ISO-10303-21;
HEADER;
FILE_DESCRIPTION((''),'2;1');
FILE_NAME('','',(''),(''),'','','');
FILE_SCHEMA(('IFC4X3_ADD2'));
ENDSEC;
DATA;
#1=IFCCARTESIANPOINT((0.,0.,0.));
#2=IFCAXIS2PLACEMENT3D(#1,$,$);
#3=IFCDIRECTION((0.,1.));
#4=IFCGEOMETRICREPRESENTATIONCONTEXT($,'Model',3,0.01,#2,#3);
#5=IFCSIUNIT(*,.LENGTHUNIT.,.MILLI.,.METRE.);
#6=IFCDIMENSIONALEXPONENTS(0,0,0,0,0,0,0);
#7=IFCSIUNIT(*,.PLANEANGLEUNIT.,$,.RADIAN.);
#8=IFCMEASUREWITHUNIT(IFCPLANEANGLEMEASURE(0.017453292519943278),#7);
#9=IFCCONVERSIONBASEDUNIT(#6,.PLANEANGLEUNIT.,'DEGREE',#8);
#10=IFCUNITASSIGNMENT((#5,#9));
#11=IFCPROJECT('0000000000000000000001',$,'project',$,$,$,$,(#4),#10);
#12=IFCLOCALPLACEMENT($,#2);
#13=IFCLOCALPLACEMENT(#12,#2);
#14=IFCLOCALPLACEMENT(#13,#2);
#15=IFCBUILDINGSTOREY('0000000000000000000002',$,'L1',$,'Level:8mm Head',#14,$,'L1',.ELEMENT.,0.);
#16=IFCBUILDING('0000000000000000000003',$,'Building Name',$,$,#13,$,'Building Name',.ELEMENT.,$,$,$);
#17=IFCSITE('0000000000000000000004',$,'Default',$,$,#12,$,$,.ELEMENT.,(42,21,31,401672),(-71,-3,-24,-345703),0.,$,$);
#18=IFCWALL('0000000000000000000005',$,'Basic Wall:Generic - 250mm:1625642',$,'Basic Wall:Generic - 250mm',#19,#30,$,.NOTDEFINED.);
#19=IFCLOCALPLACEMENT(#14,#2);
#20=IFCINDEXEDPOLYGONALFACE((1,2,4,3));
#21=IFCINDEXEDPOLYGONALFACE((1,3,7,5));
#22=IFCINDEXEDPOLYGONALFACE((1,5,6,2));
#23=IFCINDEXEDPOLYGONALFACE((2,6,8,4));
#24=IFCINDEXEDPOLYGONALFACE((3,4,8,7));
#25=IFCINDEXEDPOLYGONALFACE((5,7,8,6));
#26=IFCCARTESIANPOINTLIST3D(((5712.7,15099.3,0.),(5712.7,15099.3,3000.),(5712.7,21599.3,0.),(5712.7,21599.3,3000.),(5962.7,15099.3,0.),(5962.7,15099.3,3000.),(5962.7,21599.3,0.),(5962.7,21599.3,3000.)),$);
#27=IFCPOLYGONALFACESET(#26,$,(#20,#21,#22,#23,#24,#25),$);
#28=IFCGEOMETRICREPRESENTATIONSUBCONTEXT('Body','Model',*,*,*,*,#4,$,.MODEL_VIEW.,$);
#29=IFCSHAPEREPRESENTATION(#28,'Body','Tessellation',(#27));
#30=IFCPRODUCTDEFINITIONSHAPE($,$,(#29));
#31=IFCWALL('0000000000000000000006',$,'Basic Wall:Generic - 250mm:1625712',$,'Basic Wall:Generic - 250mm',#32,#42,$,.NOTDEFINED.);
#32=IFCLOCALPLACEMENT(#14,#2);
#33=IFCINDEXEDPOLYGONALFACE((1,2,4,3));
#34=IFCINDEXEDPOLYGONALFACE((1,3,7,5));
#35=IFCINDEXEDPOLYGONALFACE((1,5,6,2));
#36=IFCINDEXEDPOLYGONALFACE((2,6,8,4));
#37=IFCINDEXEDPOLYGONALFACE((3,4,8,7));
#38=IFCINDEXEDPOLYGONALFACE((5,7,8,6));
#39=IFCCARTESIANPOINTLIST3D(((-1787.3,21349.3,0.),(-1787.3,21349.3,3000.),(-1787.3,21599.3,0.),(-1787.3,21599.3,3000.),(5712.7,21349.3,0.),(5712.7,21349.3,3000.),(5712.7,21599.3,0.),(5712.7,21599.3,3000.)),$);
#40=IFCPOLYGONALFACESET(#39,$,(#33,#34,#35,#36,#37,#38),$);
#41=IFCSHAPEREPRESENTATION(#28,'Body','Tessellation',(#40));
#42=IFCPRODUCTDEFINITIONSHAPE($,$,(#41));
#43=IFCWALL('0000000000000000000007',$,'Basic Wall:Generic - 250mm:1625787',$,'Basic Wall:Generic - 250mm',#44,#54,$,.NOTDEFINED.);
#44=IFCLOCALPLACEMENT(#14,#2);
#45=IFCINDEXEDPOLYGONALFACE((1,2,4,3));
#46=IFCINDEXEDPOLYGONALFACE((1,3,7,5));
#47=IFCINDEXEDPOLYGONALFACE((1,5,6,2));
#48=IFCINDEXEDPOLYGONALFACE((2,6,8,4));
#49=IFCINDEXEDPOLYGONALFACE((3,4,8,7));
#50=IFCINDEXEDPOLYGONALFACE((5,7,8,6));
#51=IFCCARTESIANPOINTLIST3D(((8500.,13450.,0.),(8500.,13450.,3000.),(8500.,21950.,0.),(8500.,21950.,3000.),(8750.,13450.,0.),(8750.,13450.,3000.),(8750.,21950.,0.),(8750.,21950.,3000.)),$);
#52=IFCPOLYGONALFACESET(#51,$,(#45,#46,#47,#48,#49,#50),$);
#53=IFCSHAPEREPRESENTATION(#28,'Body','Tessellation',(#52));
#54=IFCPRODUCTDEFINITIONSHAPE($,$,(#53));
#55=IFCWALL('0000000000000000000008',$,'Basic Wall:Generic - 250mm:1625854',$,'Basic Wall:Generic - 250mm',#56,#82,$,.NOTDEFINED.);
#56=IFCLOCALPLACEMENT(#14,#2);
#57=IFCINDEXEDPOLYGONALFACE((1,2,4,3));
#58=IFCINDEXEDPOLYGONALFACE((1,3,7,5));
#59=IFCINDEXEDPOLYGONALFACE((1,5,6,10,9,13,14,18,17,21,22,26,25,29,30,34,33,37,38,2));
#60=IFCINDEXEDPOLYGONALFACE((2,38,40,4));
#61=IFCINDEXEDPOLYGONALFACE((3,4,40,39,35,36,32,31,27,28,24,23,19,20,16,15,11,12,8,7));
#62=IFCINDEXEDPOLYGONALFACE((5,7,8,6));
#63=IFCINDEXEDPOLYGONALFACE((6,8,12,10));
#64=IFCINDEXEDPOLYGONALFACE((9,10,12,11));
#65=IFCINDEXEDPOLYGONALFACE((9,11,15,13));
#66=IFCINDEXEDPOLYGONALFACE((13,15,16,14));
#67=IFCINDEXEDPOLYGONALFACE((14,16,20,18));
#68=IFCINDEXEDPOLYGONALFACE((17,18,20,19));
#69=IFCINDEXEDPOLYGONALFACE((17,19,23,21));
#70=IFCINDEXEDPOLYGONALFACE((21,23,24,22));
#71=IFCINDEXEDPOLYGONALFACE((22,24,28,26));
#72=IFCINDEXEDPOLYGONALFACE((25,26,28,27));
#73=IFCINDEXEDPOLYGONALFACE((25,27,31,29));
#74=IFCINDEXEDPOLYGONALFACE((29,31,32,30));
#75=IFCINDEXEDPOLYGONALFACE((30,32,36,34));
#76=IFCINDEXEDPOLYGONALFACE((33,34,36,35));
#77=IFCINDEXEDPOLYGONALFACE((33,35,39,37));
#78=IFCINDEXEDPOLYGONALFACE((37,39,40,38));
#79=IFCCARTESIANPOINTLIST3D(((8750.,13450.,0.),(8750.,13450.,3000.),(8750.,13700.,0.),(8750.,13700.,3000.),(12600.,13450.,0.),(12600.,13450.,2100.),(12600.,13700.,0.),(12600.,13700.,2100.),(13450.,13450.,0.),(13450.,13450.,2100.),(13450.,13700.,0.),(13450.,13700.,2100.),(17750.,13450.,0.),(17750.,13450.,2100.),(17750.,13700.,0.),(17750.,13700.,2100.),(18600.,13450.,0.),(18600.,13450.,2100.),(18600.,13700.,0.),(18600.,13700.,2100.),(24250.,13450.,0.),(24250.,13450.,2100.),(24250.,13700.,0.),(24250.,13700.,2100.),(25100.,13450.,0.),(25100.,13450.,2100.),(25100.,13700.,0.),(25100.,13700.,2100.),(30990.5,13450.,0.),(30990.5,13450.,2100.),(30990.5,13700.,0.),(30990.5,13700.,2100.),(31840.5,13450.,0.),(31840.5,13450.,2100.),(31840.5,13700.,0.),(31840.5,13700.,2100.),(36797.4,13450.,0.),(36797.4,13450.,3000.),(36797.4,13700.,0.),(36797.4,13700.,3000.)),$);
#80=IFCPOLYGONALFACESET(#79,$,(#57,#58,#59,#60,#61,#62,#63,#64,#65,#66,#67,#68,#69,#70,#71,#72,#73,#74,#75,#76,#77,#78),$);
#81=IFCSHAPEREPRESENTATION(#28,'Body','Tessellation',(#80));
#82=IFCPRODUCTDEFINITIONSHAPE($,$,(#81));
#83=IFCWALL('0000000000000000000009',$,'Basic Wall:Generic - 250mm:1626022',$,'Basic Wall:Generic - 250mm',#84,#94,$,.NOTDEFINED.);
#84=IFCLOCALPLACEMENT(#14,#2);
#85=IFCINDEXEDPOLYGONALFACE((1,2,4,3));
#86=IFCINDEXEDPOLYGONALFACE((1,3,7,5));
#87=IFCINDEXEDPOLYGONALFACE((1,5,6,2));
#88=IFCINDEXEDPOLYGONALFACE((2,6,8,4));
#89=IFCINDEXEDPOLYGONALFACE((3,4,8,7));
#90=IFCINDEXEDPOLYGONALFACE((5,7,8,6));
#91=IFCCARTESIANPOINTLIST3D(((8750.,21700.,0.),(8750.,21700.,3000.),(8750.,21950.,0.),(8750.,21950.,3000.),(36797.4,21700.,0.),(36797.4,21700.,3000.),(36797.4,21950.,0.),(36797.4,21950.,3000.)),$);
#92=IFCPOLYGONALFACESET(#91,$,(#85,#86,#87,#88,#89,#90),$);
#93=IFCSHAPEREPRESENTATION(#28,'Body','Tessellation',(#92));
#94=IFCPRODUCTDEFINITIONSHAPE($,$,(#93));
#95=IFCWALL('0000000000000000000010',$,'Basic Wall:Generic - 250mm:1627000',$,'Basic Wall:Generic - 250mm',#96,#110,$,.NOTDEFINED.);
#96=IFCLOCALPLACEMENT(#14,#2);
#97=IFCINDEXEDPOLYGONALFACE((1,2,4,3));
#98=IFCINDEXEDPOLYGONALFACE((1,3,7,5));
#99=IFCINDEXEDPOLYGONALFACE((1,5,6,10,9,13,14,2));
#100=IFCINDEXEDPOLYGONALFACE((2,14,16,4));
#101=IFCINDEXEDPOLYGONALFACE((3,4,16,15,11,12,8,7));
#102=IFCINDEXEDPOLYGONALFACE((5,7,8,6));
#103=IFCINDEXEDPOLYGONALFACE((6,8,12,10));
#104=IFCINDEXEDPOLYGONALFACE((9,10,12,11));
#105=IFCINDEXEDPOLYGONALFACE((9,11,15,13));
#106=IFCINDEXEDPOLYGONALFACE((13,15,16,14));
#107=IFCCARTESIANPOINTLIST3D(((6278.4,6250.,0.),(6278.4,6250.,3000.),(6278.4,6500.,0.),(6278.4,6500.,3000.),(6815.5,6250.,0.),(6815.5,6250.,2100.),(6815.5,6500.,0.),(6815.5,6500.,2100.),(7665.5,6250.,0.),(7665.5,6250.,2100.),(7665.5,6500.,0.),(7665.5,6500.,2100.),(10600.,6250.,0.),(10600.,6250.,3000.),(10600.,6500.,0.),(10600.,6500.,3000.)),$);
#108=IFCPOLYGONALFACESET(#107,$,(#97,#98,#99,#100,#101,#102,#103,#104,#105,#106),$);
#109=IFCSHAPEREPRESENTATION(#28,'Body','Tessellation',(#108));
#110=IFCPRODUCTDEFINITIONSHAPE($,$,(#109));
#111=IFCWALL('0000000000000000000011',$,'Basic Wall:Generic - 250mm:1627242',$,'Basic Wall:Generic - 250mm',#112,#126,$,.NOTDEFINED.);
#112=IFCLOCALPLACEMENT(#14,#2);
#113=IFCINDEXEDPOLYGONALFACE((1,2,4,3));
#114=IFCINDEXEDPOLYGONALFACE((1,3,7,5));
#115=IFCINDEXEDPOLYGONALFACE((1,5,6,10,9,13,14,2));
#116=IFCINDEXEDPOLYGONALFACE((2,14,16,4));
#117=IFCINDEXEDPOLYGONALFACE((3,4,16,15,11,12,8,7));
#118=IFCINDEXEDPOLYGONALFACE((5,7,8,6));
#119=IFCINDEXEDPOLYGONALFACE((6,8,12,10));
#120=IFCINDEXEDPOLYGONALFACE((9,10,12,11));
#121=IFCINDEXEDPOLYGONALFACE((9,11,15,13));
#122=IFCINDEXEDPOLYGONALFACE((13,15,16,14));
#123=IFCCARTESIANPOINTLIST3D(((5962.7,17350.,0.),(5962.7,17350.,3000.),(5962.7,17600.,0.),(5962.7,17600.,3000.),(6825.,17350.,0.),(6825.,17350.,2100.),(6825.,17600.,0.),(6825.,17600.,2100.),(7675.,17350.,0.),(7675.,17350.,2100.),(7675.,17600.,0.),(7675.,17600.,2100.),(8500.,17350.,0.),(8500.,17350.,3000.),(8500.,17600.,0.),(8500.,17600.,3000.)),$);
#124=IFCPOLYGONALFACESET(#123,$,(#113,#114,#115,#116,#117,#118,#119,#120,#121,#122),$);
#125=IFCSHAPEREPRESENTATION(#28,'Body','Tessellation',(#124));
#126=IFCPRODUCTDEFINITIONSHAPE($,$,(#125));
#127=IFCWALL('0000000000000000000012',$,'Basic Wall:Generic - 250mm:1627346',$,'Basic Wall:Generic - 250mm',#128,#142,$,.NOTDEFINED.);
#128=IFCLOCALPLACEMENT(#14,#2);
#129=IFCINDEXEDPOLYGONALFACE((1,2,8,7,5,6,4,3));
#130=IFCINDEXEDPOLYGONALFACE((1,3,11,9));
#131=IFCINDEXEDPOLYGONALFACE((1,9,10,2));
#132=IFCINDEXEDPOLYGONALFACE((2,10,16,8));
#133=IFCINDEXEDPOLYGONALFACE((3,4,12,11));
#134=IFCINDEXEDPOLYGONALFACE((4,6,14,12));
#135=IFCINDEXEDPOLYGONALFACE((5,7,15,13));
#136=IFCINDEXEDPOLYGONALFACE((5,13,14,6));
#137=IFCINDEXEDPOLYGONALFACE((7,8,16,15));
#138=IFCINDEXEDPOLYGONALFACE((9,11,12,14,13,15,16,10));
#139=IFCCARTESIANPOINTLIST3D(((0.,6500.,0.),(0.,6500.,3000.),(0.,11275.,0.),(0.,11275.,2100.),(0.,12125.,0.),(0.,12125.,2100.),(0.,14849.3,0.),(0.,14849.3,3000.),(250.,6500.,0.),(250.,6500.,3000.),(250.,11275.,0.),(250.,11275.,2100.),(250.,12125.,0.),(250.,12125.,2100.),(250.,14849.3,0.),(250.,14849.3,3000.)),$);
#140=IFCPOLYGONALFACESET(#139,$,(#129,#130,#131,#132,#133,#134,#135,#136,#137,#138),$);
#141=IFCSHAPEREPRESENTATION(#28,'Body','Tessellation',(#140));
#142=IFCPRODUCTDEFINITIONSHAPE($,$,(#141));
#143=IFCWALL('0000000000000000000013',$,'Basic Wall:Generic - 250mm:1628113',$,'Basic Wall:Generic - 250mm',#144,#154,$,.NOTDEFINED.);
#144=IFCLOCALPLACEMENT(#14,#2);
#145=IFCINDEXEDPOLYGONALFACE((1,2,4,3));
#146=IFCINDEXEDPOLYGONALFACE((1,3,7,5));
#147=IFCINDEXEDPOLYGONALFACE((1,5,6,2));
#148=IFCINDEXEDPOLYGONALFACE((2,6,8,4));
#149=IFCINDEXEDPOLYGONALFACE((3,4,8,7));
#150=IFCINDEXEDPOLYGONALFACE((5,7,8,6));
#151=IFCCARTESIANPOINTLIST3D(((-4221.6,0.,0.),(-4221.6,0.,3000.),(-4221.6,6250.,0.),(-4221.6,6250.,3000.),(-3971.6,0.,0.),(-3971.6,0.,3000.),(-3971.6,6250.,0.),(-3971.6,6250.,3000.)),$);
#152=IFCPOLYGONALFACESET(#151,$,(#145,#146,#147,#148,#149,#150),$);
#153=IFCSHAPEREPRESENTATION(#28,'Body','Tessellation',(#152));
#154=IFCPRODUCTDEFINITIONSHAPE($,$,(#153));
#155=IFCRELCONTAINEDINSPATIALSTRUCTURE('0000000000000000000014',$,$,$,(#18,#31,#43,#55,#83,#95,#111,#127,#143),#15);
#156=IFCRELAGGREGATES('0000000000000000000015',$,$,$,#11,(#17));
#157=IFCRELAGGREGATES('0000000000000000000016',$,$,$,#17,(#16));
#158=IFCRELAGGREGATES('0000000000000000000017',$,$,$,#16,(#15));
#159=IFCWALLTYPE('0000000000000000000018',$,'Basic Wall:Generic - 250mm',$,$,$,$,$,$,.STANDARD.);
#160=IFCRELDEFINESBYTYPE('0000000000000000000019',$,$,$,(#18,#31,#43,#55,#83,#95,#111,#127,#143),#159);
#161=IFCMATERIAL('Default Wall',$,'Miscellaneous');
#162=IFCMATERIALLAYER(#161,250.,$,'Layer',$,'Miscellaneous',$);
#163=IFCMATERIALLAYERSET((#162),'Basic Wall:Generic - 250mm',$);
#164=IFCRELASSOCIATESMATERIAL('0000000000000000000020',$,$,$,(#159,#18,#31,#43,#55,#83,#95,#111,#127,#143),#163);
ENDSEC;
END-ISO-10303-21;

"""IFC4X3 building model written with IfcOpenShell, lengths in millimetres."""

from ifc_helpers import new_model, entity, si_unit, converted_unit, direction, frame, frame_2d, origin, place, context, subcontext, project, spatial, rectangle, extrude, material, layer, layer_set, type_object, element, save


model = new_model("IFC4X3")

# Units and contexts
model_context = context("Model", 3, precision=0.01, world=origin(), true_north=direction((0.0, 1.0)))
body_context = subcontext(model_context, "Body", "Model", "MODEL_VIEW")
ifc_project = project(units=[si_unit("LENGTHUNIT", "METRE", prefix="MILLI"), converted_unit("PLANEANGLEUNIT", "DEGREE", entity("IfcPlaneAngleMeasure", 0.017453292519943278), si_unit("PLANEANGLEUNIT", "RADIAN"), dimensions=[0, 0, 0, 0, 0, 0, 0])], contexts=[model_context])

# Site, building, storey
site_placement = place(None, origin())
site = spatial("IfcSite", under=ifc_project, at=site_placement, Name="Default", CompositionType="ELEMENT", RefLatitude=(42, 21, 31, 401672), RefLongitude=(-71, -3, -24, -345703), RefElevation=0.0)
building_placement = place(site_placement, origin())
building = spatial("IfcBuilding", under=site, at=building_placement, Name="Building Name", LongName="Building Name", CompositionType="ELEMENT")
storey_placement = place(building_placement, origin())
storey = spatial("IfcBuildingStorey", under=building, at=storey_placement, Name="L1", ObjectType="Level:8mm Head", LongName="L1", CompositionType="ELEMENT", Elevation=0.0)

# Shared definitions
ifc_material = material(Name="Default Wall", Category="Miscellaneous")
ifc_layer = layer(ifc_material, 250.0, Name="Layer", Category="Miscellaneous")
ifc_layer_set = layer_set([ifc_layer], Name="Basic Wall:Generic - 250mm")
wall_type = type_object("IfcWallType", Name="Basic Wall:Generic - 250mm", PredefinedType="STANDARD", material=ifc_layer_set)

# Walls
wall_1_placement = place(storey_placement, frame((5837.7, 15099.3, 0.0), z_axis=(0.0, 0.0, 1.0), x_axis=(0.0, 1.0, 0.0)))
element("IfcWall", 1, at=wall_1_placement, inside=storey, type_object=wall_type, material=ifc_layer_set, Name="Basic Wall:Generic - 250mm:1625642", ObjectType="Basic Wall:Generic - 250mm", PredefinedType="NOTDEFINED", context=body_context, shape_type="SweptSolid", body=[
    extrude(rectangle(XDim=6500.0, YDim=250.0, at=frame_2d((3250.0, 0.0), x_axis=(-1.0, 0.0))), origin(), (0.0, 0.0, 1.0), 3000.0),
])
wall_2_placement = place(storey_placement, frame((5712.7, 21474.3, 0.0), z_axis=(0.0, 0.0, 1.0), x_axis=(-1.0, 0.0, 0.0)))
element("IfcWall", 2, at=wall_2_placement, inside=storey, type_object=wall_type, material=ifc_layer_set, Name="Basic Wall:Generic - 250mm:1625712", ObjectType="Basic Wall:Generic - 250mm", PredefinedType="NOTDEFINED", context=body_context, shape_type="SweptSolid", body=[
    extrude(rectangle(XDim=7500.0, YDim=250.0, at=frame_2d((3750.0, 0.0), x_axis=(-1.0, 0.0))), origin(), (0.0, 0.0, 1.0), 3000.0),
])
wall_3_placement = place(storey_placement, frame((8625.0, 21950.0, 0.0), z_axis=(0.0, 0.0, 1.0), x_axis=(0.0, -1.0, 0.0)))
element("IfcWall", 3, at=wall_3_placement, inside=storey, type_object=wall_type, material=ifc_layer_set, Name="Basic Wall:Generic - 250mm:1625787", ObjectType="Basic Wall:Generic - 250mm", PredefinedType="NOTDEFINED", context=body_context, shape_type="SweptSolid", body=[
    extrude(rectangle(XDim=8500.0, YDim=250.0, at=frame_2d((4250.0, 0.0), x_axis=(-1.0, 0.0))), origin(), (0.0, 0.0, 1.0), 3000.0),
])

# Wall, openings
wall_4_placement = place(storey_placement, frame((8750.0, 13575.0, 0.0)))
wall_4 = element("IfcWall", 4, at=wall_4_placement, inside=storey, type_object=wall_type, material=ifc_layer_set, Name="Basic Wall:Generic - 250mm:1625854", ObjectType="Basic Wall:Generic - 250mm", PredefinedType="NOTDEFINED", context=body_context, shape_type="SweptSolid", body=[
    extrude(rectangle(XDim=28047.4, YDim=250.0, at=frame_2d((14023.7, 0.0), x_axis=(-1.0, 0.0))), origin(), (0.0, 0.0, 1.0), 3000.0),
])
opening_1_placement = place(wall_4_placement, frame((9000.0, -125.0, 0.0)))
element("IfcOpeningElement", 5, at=opening_1_placement, cuts=wall_4, PredefinedType="OPENING", context=body_context, shape_type="SweptSolid", body=[
    extrude(rectangle(XDim=2100.0, YDim=850.0, at=frame_2d((1050.0, 425.0), x_axis=(1.0, 0.0))), frame((0.0, 0.0, 0.0), z_axis=(0.0, 1.0, 0.0), x_axis=(0.0, 0.0, 1.0)), (0.0, 0.0, 1.0), 250.0),
])
opening_2_placement = place(wall_4_placement, frame((3850.0, -125.0, 0.0)))
element("IfcOpeningElement", 6, at=opening_2_placement, cuts=wall_4, PredefinedType="OPENING", context=body_context, shape_type="SweptSolid", body=[
    extrude(rectangle(XDim=2100.0, YDim=850.0, at=frame_2d((1050.0, 425.0), x_axis=(1.0, 0.0))), frame((0.0, 0.0, 0.0), z_axis=(0.0, 1.0, 0.0), x_axis=(0.0, 0.0, 1.0)), (0.0, 0.0, 1.0), 250.0),
])
opening_3_placement = place(wall_4_placement, frame((22240.5, -125.0, 0.0)))
element("IfcOpeningElement", 7, at=opening_3_placement, cuts=wall_4, PredefinedType="OPENING", context=body_context, shape_type="SweptSolid", body=[
    extrude(rectangle(XDim=2100.0, YDim=850.0, at=frame_2d((1050.0, 425.0), x_axis=(1.0, 0.0))), frame((0.0, 0.0, 0.0), z_axis=(0.0, 1.0, 0.0), x_axis=(0.0, 0.0, 1.0)), (0.0, 0.0, 1.0), 250.0),
])
opening_4_placement = place(wall_4_placement, frame((15500.0, -125.0, 0.0)))
element("IfcOpeningElement", 8, at=opening_4_placement, cuts=wall_4, PredefinedType="OPENING", context=body_context, shape_type="SweptSolid", body=[
    extrude(rectangle(XDim=2100.0, YDim=850.0, at=frame_2d((1050.0, 425.0), x_axis=(1.0, 0.0))), frame((0.0, 0.0, 0.0), z_axis=(0.0, 1.0, 0.0), x_axis=(0.0, 0.0, 1.0)), (0.0, 0.0, 1.0), 250.0),
])

# Wall
wall_5_placement = place(storey_placement, frame((36797.4, 21825.0, 0.0), z_axis=(0.0, 0.0, 1.0), x_axis=(-1.0, 0.0, 0.0)))
element("IfcWall", 9, at=wall_5_placement, inside=storey, type_object=wall_type, material=ifc_layer_set, Name="Basic Wall:Generic - 250mm:1626022", ObjectType="Basic Wall:Generic - 250mm", PredefinedType="NOTDEFINED", context=body_context, shape_type="SweptSolid", body=[
    extrude(rectangle(XDim=28047.4, YDim=250.0, at=frame_2d((14023.7, 0.0), x_axis=(-1.0, 0.0))), origin(), (0.0, 0.0, 1.0), 3000.0),
])

# Walls, openings
wall_6_placement = place(storey_placement, frame((10600.0, 6375.0, 0.0), z_axis=(0.0, 0.0, 1.0), x_axis=(-1.0, 0.0, 0.0)))
wall_6 = element("IfcWall", 10, at=wall_6_placement, inside=storey, type_object=wall_type, material=ifc_layer_set, Name="Basic Wall:Generic - 250mm:1627000", ObjectType="Basic Wall:Generic - 250mm", PredefinedType="NOTDEFINED", context=body_context, shape_type="SweptSolid", body=[
    extrude(rectangle(XDim=4321.6, YDim=250.0, at=frame_2d((2160.8, 0.0), x_axis=(-1.0, 0.0))), origin(), (0.0, 0.0, 1.0), 3000.0),
])
opening_5_placement = place(wall_6_placement, frame((3784.5, 125.0, 0.0)))
element("IfcOpeningElement", 11, at=opening_5_placement, cuts=wall_6, PredefinedType="OPENING", context=body_context, shape_type="SweptSolid", body=[
    extrude(rectangle(XDim=2100.0, YDim=850.0, at=frame_2d((1050.0, 425.0), x_axis=(1.0, 0.0))), frame((0.0, 0.0, 0.0), z_axis=(0.0, -1.0, 0.0), x_axis=(0.0, 0.0, 1.0)), (0.0, 0.0, 1.0), 250.0),
])
wall_7_placement = place(storey_placement, frame((5962.7, 17475.0, 0.0)))
wall_7 = element("IfcWall", 12, at=wall_7_placement, inside=storey, type_object=wall_type, material=ifc_layer_set, Name="Basic Wall:Generic - 250mm:1627242", ObjectType="Basic Wall:Generic - 250mm", PredefinedType="NOTDEFINED", context=body_context, shape_type="SweptSolid", body=[
    extrude(rectangle(XDim=2537.3, YDim=250.0, at=frame_2d((1268.6, 0.0), x_axis=(-1.0, 0.0))), origin(), (0.0, 0.0, 1.0), 3000.0),
])
opening_6_placement = place(wall_7_placement, frame((862.3, -125.0, 0.0)))
element("IfcOpeningElement", 13, at=opening_6_placement, cuts=wall_7, PredefinedType="OPENING", context=body_context, shape_type="SweptSolid", body=[
    extrude(rectangle(XDim=2100.0, YDim=850.0, at=frame_2d((1050.0, 425.0), x_axis=(1.0, 0.0))), frame((0.0, 0.0, 0.0), z_axis=(0.0, 1.0, 0.0), x_axis=(0.0, 0.0, 1.0)), (0.0, 0.0, 1.0), 250.0),
])
wall_8_placement = place(storey_placement, frame((125.0, 6500.0, 0.0), z_axis=(0.0, 0.0, 1.0), x_axis=(0.0, 1.0, 0.0)))
wall_8 = element("IfcWall", 14, at=wall_8_placement, inside=storey, type_object=wall_type, material=ifc_layer_set, Name="Basic Wall:Generic - 250mm:1627346", ObjectType="Basic Wall:Generic - 250mm", PredefinedType="NOTDEFINED", context=body_context, shape_type="SweptSolid", body=[
    extrude(rectangle(XDim=8349.3, YDim=250.0, at=frame_2d((4174.6, 0.0), x_axis=(1.0, 0.0))), origin(), (0.0, 0.0, 1.0), 3000.0),
])
opening_7_placement = place(wall_8_placement, frame((5625.0, 125.0, 0.0)))
element("IfcOpeningElement", 15, at=opening_7_placement, cuts=wall_8, PredefinedType="OPENING", context=body_context, shape_type="SweptSolid", body=[
    extrude(rectangle(XDim=2100.0, YDim=850.0, at=frame_2d((1050.0, 425.0), x_axis=(1.0, 0.0))), frame((0.0, 0.0, 0.0), z_axis=(0.0, -1.0, 0.0), x_axis=(0.0, 0.0, 1.0)), (0.0, 0.0, 1.0), 250.0),
])

# Wall
wall_9_placement = place(storey_placement, frame((-4096.6, 6250.0, 0.0), z_axis=(0.0, 0.0, 1.0), x_axis=(0.0, -1.0, 0.0)))
element("IfcWall", 16, at=wall_9_placement, inside=storey, type_object=wall_type, material=ifc_layer_set, Name="Basic Wall:Generic - 250mm:1628113", ObjectType="Basic Wall:Generic - 250mm", PredefinedType="NOTDEFINED", context=body_context, shape_type="SweptSolid", body=[
    extrude(rectangle(XDim=6250.0, YDim=250.0, at=frame_2d((3125.0, 0.0), x_axis=(-1.0, 0.0))), origin(), (0.0, 0.0, 1.0), 3000.0),
])

save(model, "model.ifc")
